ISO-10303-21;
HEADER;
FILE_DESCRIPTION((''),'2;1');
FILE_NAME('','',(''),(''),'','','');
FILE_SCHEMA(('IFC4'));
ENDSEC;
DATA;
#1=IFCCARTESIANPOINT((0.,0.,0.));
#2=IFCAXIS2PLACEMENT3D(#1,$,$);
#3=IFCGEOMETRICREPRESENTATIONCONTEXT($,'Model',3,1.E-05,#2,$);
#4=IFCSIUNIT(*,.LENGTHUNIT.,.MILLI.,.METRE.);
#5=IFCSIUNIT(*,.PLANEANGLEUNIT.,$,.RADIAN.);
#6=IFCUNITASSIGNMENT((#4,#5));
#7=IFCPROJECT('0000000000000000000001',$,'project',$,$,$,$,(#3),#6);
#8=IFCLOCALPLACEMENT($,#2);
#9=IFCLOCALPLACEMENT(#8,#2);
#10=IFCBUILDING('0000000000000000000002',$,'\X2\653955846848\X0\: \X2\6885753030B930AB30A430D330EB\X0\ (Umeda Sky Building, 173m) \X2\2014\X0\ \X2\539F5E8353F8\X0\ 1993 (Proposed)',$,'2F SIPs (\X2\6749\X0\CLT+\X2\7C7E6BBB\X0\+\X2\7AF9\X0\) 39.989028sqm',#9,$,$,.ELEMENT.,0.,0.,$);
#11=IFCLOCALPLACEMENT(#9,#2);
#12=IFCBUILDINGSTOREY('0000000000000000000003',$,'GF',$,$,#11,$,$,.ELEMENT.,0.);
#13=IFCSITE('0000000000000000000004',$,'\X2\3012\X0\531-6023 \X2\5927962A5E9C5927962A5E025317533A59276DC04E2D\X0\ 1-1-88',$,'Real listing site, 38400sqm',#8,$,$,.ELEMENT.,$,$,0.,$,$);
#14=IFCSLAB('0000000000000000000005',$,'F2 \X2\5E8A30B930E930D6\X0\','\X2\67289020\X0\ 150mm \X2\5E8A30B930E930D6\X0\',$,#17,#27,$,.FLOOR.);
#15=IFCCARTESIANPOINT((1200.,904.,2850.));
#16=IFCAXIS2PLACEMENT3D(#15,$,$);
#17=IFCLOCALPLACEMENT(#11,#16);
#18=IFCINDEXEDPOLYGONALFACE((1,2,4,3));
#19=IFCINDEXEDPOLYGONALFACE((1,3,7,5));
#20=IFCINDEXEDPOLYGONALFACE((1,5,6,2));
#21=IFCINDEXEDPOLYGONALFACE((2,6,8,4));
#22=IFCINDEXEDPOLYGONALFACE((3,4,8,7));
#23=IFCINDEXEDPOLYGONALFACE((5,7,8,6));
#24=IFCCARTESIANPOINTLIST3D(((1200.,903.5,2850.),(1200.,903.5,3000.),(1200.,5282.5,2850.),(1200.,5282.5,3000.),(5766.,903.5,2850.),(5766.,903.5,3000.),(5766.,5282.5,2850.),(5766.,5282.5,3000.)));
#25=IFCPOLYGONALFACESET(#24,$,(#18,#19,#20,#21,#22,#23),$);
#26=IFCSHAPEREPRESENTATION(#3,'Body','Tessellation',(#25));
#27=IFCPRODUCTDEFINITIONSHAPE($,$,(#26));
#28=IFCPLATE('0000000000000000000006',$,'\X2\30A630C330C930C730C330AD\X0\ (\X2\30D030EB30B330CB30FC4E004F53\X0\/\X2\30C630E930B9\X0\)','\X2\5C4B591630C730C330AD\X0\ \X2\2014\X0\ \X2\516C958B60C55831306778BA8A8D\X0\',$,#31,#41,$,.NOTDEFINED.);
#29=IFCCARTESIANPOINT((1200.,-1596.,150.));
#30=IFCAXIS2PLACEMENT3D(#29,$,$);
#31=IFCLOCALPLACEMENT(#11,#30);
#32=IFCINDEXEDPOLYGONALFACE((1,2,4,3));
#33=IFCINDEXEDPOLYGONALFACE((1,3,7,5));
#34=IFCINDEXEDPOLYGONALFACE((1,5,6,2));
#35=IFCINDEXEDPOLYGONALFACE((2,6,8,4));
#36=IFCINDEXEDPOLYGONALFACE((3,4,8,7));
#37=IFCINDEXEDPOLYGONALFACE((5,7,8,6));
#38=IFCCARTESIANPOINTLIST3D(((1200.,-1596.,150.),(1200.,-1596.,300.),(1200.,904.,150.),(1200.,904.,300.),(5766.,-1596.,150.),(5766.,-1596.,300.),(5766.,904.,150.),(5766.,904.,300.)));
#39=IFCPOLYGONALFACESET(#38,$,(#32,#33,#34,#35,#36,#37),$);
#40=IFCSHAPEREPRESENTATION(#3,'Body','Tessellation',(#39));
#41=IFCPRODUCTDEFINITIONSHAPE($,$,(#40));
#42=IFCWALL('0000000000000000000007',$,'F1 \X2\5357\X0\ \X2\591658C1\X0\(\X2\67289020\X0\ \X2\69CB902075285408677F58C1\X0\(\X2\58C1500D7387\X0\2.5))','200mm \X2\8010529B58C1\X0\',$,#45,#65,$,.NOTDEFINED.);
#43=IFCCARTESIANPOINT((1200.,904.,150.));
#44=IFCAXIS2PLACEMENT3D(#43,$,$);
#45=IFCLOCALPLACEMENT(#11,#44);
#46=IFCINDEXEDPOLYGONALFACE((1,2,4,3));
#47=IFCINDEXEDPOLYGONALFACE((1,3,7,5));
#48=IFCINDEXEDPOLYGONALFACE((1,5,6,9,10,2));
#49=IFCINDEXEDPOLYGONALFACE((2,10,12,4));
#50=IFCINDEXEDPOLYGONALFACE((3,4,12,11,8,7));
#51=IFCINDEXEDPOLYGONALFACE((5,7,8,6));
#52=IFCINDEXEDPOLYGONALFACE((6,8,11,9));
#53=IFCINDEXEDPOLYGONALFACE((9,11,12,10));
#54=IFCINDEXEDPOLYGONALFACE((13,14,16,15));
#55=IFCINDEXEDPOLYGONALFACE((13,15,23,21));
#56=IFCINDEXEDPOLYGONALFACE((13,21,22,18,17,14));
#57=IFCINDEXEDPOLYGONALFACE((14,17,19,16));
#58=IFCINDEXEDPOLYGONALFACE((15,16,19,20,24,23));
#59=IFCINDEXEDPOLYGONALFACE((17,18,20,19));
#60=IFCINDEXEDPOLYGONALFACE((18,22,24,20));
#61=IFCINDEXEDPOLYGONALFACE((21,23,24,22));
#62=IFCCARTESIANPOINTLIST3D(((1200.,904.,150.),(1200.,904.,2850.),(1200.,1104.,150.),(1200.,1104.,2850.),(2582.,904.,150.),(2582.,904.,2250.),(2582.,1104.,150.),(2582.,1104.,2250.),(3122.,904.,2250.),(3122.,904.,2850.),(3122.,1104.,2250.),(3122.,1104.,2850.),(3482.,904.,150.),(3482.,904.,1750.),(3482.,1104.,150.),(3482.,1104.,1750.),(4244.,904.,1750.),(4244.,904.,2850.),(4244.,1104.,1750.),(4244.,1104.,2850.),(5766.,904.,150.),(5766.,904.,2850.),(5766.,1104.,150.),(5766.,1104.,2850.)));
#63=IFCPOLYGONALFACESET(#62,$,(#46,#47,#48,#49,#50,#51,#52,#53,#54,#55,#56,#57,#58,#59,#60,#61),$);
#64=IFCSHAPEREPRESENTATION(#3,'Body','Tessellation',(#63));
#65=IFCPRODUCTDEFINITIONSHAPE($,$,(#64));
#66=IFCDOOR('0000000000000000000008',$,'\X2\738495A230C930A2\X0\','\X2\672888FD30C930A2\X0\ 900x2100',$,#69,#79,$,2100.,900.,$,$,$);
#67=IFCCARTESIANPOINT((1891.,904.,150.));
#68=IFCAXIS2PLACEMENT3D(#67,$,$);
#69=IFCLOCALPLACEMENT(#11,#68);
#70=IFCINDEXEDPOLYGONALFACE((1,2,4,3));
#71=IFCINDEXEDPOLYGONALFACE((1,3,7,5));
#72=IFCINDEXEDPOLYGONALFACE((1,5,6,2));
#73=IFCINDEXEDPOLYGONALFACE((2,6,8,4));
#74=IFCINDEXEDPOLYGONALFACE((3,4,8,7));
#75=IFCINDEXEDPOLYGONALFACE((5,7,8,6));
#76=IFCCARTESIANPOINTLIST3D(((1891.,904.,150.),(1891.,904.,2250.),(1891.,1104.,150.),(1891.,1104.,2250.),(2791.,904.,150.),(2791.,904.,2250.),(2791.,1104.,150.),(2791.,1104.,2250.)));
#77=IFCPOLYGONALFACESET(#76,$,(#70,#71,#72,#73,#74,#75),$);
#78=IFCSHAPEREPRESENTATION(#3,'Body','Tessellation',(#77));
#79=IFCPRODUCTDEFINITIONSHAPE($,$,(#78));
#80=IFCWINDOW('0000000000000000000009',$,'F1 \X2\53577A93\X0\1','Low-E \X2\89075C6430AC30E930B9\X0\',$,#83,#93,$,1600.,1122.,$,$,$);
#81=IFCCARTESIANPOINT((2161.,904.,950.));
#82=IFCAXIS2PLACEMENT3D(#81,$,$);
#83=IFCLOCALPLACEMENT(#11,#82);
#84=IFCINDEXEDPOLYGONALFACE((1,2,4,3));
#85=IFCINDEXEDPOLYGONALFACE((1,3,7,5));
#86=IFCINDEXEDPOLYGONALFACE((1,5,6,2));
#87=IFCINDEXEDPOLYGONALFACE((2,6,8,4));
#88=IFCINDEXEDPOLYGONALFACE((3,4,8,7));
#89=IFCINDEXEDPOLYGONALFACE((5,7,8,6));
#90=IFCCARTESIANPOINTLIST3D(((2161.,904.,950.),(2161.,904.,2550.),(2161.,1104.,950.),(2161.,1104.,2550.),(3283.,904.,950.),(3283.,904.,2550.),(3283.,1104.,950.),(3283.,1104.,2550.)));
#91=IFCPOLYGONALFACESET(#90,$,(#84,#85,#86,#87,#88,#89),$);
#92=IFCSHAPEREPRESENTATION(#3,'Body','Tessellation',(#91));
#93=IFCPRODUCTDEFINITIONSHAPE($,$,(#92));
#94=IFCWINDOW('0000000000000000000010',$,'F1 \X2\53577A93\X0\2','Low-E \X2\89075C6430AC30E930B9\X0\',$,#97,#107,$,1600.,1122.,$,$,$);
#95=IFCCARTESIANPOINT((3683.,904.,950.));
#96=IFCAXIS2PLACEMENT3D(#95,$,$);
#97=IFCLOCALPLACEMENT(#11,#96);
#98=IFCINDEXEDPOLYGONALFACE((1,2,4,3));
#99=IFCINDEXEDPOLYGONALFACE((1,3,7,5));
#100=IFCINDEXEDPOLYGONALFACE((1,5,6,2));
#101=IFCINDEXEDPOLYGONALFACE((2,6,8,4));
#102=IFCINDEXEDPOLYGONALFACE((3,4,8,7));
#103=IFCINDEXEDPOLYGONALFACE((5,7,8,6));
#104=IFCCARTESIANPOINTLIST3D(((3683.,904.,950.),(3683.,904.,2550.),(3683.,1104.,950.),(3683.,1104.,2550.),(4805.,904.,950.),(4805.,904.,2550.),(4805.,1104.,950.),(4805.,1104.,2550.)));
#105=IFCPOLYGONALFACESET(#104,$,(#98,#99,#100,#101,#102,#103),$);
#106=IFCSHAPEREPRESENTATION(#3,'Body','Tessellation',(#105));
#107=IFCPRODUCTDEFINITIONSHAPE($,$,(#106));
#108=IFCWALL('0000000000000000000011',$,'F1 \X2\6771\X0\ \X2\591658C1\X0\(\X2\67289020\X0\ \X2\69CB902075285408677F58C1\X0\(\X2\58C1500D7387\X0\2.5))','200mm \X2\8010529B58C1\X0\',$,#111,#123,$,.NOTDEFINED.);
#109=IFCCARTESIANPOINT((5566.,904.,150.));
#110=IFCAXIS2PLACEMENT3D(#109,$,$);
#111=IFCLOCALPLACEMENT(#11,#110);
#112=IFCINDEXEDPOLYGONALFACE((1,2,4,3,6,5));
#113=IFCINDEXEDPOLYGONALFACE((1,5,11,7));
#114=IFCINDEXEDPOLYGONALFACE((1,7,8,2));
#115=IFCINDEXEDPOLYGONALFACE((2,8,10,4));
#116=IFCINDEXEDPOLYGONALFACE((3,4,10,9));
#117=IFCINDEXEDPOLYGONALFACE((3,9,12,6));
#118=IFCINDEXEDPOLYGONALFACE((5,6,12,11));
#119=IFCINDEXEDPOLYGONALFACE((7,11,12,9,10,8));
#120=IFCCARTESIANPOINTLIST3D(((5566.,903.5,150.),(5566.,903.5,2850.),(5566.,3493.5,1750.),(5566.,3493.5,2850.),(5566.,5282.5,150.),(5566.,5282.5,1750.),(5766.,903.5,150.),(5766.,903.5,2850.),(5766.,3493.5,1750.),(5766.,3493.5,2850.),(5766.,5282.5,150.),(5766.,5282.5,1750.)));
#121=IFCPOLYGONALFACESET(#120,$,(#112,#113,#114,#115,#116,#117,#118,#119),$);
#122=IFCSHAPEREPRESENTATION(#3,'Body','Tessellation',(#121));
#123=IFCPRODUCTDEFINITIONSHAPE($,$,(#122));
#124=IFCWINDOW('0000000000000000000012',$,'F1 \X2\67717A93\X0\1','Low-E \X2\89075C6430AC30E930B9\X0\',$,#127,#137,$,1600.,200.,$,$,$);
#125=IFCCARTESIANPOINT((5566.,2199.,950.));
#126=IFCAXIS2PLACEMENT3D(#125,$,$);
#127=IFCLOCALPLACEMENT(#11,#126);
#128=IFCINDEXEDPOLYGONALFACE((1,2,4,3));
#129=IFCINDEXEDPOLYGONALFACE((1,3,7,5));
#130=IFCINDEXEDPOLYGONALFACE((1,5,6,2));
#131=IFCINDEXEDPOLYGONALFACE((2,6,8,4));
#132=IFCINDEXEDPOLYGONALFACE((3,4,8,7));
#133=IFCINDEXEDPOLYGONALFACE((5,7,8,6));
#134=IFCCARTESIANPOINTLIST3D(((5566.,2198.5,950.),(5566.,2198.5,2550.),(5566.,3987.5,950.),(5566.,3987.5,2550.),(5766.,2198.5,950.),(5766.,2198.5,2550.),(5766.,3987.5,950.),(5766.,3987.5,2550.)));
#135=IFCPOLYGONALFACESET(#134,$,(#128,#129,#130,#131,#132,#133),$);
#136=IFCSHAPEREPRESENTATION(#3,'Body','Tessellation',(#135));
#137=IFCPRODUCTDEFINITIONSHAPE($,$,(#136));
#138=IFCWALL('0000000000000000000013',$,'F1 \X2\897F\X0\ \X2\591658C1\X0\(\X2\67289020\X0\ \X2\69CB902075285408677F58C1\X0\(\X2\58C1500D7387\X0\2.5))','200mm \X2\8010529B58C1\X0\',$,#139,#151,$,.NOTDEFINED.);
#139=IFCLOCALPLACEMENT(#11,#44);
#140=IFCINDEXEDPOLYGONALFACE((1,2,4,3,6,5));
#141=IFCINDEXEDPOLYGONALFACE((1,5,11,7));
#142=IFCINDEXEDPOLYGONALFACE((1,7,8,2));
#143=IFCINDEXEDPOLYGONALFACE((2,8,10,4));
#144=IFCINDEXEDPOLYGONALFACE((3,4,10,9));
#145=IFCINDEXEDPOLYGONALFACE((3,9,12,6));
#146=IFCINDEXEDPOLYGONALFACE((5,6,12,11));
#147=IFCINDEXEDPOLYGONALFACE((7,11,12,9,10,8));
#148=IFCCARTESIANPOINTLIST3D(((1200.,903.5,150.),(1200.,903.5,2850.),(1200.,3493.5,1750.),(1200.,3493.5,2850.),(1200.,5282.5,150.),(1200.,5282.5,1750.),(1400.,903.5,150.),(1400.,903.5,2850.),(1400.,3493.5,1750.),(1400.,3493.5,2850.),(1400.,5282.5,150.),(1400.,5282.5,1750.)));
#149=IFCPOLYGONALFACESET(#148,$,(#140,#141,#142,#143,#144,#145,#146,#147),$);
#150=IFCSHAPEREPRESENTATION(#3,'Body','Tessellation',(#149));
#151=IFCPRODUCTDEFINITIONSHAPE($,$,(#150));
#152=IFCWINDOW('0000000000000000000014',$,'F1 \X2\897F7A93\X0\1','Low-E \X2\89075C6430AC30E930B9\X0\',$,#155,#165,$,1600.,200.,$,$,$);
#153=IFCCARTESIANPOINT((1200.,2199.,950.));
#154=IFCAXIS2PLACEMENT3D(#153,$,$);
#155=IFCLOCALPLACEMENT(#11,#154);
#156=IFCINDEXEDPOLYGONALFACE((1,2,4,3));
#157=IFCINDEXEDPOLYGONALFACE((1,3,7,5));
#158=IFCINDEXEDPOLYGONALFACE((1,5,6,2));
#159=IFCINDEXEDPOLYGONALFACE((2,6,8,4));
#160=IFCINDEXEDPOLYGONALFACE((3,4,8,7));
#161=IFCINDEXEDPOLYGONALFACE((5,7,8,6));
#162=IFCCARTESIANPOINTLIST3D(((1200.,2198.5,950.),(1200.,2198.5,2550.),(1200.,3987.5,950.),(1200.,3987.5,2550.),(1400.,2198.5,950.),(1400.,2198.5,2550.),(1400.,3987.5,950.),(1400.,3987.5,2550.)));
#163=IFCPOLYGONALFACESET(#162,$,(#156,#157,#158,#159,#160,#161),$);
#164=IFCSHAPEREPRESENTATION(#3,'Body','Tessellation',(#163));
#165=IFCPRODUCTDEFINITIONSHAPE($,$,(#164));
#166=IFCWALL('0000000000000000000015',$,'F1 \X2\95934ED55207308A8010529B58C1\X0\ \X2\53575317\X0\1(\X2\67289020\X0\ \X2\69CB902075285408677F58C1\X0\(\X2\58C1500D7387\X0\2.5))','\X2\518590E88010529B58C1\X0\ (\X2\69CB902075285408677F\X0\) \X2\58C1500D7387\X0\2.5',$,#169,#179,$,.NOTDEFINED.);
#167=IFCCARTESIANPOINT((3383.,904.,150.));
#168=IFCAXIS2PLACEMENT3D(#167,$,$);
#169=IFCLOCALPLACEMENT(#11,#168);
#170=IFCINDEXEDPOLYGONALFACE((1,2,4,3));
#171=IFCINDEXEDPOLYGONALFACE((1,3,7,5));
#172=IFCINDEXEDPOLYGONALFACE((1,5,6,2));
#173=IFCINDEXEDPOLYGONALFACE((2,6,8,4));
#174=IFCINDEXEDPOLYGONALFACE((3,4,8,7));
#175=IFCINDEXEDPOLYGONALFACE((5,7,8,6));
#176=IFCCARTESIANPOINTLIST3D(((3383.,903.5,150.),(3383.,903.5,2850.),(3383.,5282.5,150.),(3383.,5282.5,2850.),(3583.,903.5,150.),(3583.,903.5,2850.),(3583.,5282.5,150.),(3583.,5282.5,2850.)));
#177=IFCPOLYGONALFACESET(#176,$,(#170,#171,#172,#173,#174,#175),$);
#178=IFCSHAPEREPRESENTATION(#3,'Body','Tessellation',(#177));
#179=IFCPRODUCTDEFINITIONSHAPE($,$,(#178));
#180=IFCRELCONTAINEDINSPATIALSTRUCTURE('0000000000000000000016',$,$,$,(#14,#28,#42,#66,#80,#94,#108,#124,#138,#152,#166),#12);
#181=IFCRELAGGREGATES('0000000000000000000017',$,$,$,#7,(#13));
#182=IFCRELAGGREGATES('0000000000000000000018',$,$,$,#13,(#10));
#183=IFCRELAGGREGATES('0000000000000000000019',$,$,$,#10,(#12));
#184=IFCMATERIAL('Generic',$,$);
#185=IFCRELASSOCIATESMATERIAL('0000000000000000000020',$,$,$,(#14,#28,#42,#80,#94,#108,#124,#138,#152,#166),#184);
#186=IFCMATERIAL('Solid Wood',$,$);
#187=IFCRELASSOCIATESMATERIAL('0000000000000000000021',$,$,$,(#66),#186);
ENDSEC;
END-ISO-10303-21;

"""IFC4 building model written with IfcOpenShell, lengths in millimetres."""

from ifc_helpers import new_model, si_unit, frame, frame_2d, origin, place, context, project, spatial, rectangle, extrude, material, element, fill, save


model = new_model("IFC4")

# Units and contexts
model_context = context("Model", 3, precision=1e-05, world=origin())
ifc_project = project(units=[si_unit("LENGTHUNIT", "METRE", prefix="MILLI"), si_unit("PLANEANGLEUNIT", "RADIAN")], contexts=[model_context])

# Site, building, storey
site_placement = place(None, origin())
site = spatial("IfcSite", under=ifc_project, at=site_placement, Name="〒531-6023 大阪府大阪市北区大淀中 1-1-88", ObjectType="Real listing site, 38400sqm", CompositionType="ELEMENT", RefElevation=0.0)
building_placement = place(site_placement, origin())
building = spatial("IfcBuilding", under=site, at=building_placement, Name="改善案: 梅田スカイビル (Umeda Sky Building, 173m) — 原広司 1993 (Proposed)", ObjectType="2F SIPs (杉CLT+籾殻+竹) 39.989028sqm", CompositionType="ELEMENT", ElevationOfRefHeight=0.0, ElevationOfTerrain=0.0)
storey_placement = place(building_placement, origin())
storey = spatial("IfcBuildingStorey", under=building, at=storey_placement, Name="GF", CompositionType="ELEMENT", Elevation=0.0)

# Slab
ifc_material_1 = material(Name="Generic")
slab_1_placement = place(storey_placement, frame((1200.0, 904.0, 2850.0)))
element("IfcSlab", 1, at=slab_1_placement, inside=storey, material=ifc_material_1, Name="F2 床スラブ", Description="木造 150mm 床スラブ", PredefinedType="FLOOR", context=model_context, shape_type="SweptSolid", body=[
    extrude(rectangle(XDim=4566.0, YDim=4379.0, at=frame_2d((2283.0, 2189.0))), frame((1200.0, 904.0, 2850.0)), (0.0, 0.0, 1.0), 150.0),
])

# Plate
plate_placement = place(storey_placement, frame((1200.0, -1596.0, 150.0)))
element("IfcPlate", 2, at=plate_placement, inside=storey, material=ifc_material_1, Name="ウッドデッキ (バルコニー一体/テラス)", Description="屋外デッキ — 公開情報で確認", PredefinedType="NOTDEFINED", context=model_context, shape_type="SweptSolid", body=[
    extrude(rectangle(XDim=4566.0, YDim=2500.0, at=frame_2d((2283.0, 1250.0))), frame((1200.0, -1596.0, 150.0)), (0.0, 0.0, 1.0), 150.0),
])

# Wall, openings, door, windows
wall_1_placement = place(storey_placement, frame((1200.0, 904.0, 150.0)))
wall_1 = element("IfcWall", 3, at=wall_1_placement, inside=storey, material=ifc_material_1, Name="F1 南 外壁(木造 構造用合板壁(壁倍率2.5))", Description="200mm 耐力壁", PredefinedType="NOTDEFINED", context=model_context, shape_type="SweptSolid", body=[
    extrude(rectangle(XDim=4566.0, YDim=200.0, at=frame_2d((2283.0, 100.0))), frame((1200.0, 904.0, 150.0)), (0.0, 0.0, 1.0), 2700.0),
])
opening_1_placement = place(storey_placement, frame((1891.0, 904.0, 150.0)))
opening_1 = element("IfcOpeningElement", 4, at=opening_1_placement, cuts=wall_1, PredefinedType="NOTDEFINED", context=model_context, shape_type="SweptSolid", body=[
    extrude(rectangle(XDim=900.0, YDim=200.0, at=frame_2d((450.0, 100.0))), frame((1891.0, 904.0, 150.0)), (0.0, 0.0, 1.0), 2100.0),
])
opening_2_placement = place(storey_placement, frame((2161.0, 904.0, 950.0)))
opening_2 = element("IfcOpeningElement", 5, at=opening_2_placement, cuts=wall_1, PredefinedType="NOTDEFINED", context=model_context, shape_type="SweptSolid", body=[
    extrude(rectangle(XDim=1122.0, YDim=200.0, at=frame_2d((561.0, 100.0))), frame((2161.0, 904.0, 950.0)), (0.0, 0.0, 1.0), 1600.0),
])
opening_3_placement = place(storey_placement, frame((3683.0, 904.0, 950.0)))
opening_3 = element("IfcOpeningElement", 6, at=opening_3_placement, cuts=wall_1, PredefinedType="NOTDEFINED", context=model_context, shape_type="SweptSolid", body=[
    extrude(rectangle(XDim=1122.0, YDim=200.0, at=frame_2d((561.0, 100.0))), frame((3683.0, 904.0, 950.0)), (0.0, 0.0, 1.0), 1600.0),
])
ifc_material_2 = material(Name="Solid Wood")
door_placement = place(storey_placement, frame((1891.0, 904.0, 150.0)))
door = element("IfcDoor", 7, at=door_placement, inside=storey, material=ifc_material_2, Name="玄関ドア", Description="木製ドア 900x2100", OverallHeight=2100.0, OverallWidth=900.0, context=model_context, shape_type="SweptSolid", body=[
    extrude(rectangle(XDim=900.0, YDim=200.0, at=frame_2d((450.0, 100.0))), frame((1891.0, 904.0, 150.0)), (0.0, 0.0, 1.0), 2100.0),
])
fill(opening_1, door)
window_1_placement = place(storey_placement, frame((2161.0, 904.0, 950.0)))
window_1 = element("IfcWindow", 8, at=window_1_placement, inside=storey, material=ifc_material_1, Name="F1 南窓1", Description="Low-E 複層ガラス", OverallHeight=1600.0, OverallWidth=1122.0, context=model_context, shape_type="SweptSolid", body=[
    extrude(rectangle(XDim=1122.0, YDim=200.0, at=frame_2d((561.0, 100.0))), frame((2161.0, 904.0, 950.0)), (0.0, 0.0, 1.0), 1600.0),
])
fill(opening_2, window_1)
window_2_placement = place(storey_placement, frame((3683.0, 904.0, 950.0)))
window_2 = element("IfcWindow", 9, at=window_2_placement, inside=storey, material=ifc_material_1, Name="F1 南窓2", Description="Low-E 複層ガラス", OverallHeight=1600.0, OverallWidth=1122.0, context=model_context, shape_type="SweptSolid", body=[
    extrude(rectangle(XDim=1122.0, YDim=200.0, at=frame_2d((561.0, 100.0))), frame((3683.0, 904.0, 950.0)), (0.0, 0.0, 1.0), 1600.0),
])
fill(opening_3, window_2)

# Walls, openings, windows
wall_2_placement = place(storey_placement, frame((5566.0, 904.0, 150.0)))
wall_2 = element("IfcWall", 10, at=wall_2_placement, inside=storey, material=ifc_material_1, Name="F1 東 外壁(木造 構造用合板壁(壁倍率2.5))", Description="200mm 耐力壁", PredefinedType="NOTDEFINED", context=model_context, shape_type="SweptSolid", body=[
    extrude(rectangle(XDim=200.0, YDim=4379.0, at=frame_2d((100.0, 2189.0))), frame((5566.0, 904.0, 150.0)), (0.0, 0.0, 1.0), 2700.0),
])
opening_4_placement = place(storey_placement, frame((5566.0, 2199.0, 950.0)))
opening_4 = element("IfcOpeningElement", 11, at=opening_4_placement, cuts=wall_2, PredefinedType="NOTDEFINED", context=model_context, shape_type="SweptSolid", body=[
    extrude(rectangle(XDim=200.0, YDim=1789.0, at=frame_2d((100.0, 894.0))), frame((5566.0, 2199.0, 950.0)), (0.0, 0.0, 1.0), 1600.0),
])
window_3_placement = place(storey_placement, frame((5566.0, 2199.0, 950.0)))
window_3 = element("IfcWindow", 12, at=window_3_placement, inside=storey, material=ifc_material_1, Name="F1 東窓1", Description="Low-E 複層ガラス", OverallHeight=1600.0, OverallWidth=200.0, context=model_context, shape_type="SweptSolid", body=[
    extrude(rectangle(XDim=200.0, YDim=1789.0, at=frame_2d((100.0, 894.0))), frame((5566.0, 2199.0, 950.0)), (0.0, 0.0, 1.0), 1600.0),
])
fill(opening_4, window_3)
wall_3_placement = place(storey_placement, frame((1200.0, 904.0, 150.0)))
wall_3 = element("IfcWall", 13, at=wall_3_placement, inside=storey, material=ifc_material_1, Name="F1 西 外壁(木造 構造用合板壁(壁倍率2.5))", Description="200mm 耐力壁", PredefinedType="NOTDEFINED", context=model_context, shape_type="SweptSolid", body=[
    extrude(rectangle(XDim=200.0, YDim=4379.0, at=frame_2d((100.0, 2189.0))), frame((1200.0, 904.0, 150.0)), (0.0, 0.0, 1.0), 2700.0),
])
opening_5_placement = place(storey_placement, frame((1200.0, 2199.0, 950.0)))
opening_5 = element("IfcOpeningElement", 14, at=opening_5_placement, cuts=wall_3, PredefinedType="NOTDEFINED", context=model_context, shape_type="SweptSolid", body=[
    extrude(rectangle(XDim=200.0, YDim=1789.0, at=frame_2d((100.0, 894.0))), frame((1200.0, 2199.0, 950.0)), (0.0, 0.0, 1.0), 1600.0),
])
window_4_placement = place(storey_placement, frame((1200.0, 2199.0, 950.0)))
window_4 = element("IfcWindow", 15, at=window_4_placement, inside=storey, material=ifc_material_1, Name="F1 西窓1", Description="Low-E 複層ガラス", OverallHeight=1600.0, OverallWidth=200.0, context=model_context, shape_type="SweptSolid", body=[
    extrude(rectangle(XDim=200.0, YDim=1789.0, at=frame_2d((100.0, 894.0))), frame((1200.0, 2199.0, 950.0)), (0.0, 0.0, 1.0), 1600.0),
])
fill(opening_5, window_4)

# Wall
wall_4_placement = place(storey_placement, frame((3383.0, 904.0, 150.0)))
element("IfcWall", 16, at=wall_4_placement, inside=storey, material=ifc_material_1, Name="F1 間仕切り耐力壁 南北1(木造 構造用合板壁(壁倍率2.5))", Description="内部耐力壁 (構造用合板) 壁倍率2.5", PredefinedType="NOTDEFINED", context=model_context, shape_type="SweptSolid", body=[
    extrude(rectangle(XDim=200.0, YDim=4379.0, at=frame_2d((100.0, 2189.0))), frame((3383.0, 904.0, 150.0)), (0.0, 0.0, 1.0), 2700.0),
])

save(model, "model.ifc")
